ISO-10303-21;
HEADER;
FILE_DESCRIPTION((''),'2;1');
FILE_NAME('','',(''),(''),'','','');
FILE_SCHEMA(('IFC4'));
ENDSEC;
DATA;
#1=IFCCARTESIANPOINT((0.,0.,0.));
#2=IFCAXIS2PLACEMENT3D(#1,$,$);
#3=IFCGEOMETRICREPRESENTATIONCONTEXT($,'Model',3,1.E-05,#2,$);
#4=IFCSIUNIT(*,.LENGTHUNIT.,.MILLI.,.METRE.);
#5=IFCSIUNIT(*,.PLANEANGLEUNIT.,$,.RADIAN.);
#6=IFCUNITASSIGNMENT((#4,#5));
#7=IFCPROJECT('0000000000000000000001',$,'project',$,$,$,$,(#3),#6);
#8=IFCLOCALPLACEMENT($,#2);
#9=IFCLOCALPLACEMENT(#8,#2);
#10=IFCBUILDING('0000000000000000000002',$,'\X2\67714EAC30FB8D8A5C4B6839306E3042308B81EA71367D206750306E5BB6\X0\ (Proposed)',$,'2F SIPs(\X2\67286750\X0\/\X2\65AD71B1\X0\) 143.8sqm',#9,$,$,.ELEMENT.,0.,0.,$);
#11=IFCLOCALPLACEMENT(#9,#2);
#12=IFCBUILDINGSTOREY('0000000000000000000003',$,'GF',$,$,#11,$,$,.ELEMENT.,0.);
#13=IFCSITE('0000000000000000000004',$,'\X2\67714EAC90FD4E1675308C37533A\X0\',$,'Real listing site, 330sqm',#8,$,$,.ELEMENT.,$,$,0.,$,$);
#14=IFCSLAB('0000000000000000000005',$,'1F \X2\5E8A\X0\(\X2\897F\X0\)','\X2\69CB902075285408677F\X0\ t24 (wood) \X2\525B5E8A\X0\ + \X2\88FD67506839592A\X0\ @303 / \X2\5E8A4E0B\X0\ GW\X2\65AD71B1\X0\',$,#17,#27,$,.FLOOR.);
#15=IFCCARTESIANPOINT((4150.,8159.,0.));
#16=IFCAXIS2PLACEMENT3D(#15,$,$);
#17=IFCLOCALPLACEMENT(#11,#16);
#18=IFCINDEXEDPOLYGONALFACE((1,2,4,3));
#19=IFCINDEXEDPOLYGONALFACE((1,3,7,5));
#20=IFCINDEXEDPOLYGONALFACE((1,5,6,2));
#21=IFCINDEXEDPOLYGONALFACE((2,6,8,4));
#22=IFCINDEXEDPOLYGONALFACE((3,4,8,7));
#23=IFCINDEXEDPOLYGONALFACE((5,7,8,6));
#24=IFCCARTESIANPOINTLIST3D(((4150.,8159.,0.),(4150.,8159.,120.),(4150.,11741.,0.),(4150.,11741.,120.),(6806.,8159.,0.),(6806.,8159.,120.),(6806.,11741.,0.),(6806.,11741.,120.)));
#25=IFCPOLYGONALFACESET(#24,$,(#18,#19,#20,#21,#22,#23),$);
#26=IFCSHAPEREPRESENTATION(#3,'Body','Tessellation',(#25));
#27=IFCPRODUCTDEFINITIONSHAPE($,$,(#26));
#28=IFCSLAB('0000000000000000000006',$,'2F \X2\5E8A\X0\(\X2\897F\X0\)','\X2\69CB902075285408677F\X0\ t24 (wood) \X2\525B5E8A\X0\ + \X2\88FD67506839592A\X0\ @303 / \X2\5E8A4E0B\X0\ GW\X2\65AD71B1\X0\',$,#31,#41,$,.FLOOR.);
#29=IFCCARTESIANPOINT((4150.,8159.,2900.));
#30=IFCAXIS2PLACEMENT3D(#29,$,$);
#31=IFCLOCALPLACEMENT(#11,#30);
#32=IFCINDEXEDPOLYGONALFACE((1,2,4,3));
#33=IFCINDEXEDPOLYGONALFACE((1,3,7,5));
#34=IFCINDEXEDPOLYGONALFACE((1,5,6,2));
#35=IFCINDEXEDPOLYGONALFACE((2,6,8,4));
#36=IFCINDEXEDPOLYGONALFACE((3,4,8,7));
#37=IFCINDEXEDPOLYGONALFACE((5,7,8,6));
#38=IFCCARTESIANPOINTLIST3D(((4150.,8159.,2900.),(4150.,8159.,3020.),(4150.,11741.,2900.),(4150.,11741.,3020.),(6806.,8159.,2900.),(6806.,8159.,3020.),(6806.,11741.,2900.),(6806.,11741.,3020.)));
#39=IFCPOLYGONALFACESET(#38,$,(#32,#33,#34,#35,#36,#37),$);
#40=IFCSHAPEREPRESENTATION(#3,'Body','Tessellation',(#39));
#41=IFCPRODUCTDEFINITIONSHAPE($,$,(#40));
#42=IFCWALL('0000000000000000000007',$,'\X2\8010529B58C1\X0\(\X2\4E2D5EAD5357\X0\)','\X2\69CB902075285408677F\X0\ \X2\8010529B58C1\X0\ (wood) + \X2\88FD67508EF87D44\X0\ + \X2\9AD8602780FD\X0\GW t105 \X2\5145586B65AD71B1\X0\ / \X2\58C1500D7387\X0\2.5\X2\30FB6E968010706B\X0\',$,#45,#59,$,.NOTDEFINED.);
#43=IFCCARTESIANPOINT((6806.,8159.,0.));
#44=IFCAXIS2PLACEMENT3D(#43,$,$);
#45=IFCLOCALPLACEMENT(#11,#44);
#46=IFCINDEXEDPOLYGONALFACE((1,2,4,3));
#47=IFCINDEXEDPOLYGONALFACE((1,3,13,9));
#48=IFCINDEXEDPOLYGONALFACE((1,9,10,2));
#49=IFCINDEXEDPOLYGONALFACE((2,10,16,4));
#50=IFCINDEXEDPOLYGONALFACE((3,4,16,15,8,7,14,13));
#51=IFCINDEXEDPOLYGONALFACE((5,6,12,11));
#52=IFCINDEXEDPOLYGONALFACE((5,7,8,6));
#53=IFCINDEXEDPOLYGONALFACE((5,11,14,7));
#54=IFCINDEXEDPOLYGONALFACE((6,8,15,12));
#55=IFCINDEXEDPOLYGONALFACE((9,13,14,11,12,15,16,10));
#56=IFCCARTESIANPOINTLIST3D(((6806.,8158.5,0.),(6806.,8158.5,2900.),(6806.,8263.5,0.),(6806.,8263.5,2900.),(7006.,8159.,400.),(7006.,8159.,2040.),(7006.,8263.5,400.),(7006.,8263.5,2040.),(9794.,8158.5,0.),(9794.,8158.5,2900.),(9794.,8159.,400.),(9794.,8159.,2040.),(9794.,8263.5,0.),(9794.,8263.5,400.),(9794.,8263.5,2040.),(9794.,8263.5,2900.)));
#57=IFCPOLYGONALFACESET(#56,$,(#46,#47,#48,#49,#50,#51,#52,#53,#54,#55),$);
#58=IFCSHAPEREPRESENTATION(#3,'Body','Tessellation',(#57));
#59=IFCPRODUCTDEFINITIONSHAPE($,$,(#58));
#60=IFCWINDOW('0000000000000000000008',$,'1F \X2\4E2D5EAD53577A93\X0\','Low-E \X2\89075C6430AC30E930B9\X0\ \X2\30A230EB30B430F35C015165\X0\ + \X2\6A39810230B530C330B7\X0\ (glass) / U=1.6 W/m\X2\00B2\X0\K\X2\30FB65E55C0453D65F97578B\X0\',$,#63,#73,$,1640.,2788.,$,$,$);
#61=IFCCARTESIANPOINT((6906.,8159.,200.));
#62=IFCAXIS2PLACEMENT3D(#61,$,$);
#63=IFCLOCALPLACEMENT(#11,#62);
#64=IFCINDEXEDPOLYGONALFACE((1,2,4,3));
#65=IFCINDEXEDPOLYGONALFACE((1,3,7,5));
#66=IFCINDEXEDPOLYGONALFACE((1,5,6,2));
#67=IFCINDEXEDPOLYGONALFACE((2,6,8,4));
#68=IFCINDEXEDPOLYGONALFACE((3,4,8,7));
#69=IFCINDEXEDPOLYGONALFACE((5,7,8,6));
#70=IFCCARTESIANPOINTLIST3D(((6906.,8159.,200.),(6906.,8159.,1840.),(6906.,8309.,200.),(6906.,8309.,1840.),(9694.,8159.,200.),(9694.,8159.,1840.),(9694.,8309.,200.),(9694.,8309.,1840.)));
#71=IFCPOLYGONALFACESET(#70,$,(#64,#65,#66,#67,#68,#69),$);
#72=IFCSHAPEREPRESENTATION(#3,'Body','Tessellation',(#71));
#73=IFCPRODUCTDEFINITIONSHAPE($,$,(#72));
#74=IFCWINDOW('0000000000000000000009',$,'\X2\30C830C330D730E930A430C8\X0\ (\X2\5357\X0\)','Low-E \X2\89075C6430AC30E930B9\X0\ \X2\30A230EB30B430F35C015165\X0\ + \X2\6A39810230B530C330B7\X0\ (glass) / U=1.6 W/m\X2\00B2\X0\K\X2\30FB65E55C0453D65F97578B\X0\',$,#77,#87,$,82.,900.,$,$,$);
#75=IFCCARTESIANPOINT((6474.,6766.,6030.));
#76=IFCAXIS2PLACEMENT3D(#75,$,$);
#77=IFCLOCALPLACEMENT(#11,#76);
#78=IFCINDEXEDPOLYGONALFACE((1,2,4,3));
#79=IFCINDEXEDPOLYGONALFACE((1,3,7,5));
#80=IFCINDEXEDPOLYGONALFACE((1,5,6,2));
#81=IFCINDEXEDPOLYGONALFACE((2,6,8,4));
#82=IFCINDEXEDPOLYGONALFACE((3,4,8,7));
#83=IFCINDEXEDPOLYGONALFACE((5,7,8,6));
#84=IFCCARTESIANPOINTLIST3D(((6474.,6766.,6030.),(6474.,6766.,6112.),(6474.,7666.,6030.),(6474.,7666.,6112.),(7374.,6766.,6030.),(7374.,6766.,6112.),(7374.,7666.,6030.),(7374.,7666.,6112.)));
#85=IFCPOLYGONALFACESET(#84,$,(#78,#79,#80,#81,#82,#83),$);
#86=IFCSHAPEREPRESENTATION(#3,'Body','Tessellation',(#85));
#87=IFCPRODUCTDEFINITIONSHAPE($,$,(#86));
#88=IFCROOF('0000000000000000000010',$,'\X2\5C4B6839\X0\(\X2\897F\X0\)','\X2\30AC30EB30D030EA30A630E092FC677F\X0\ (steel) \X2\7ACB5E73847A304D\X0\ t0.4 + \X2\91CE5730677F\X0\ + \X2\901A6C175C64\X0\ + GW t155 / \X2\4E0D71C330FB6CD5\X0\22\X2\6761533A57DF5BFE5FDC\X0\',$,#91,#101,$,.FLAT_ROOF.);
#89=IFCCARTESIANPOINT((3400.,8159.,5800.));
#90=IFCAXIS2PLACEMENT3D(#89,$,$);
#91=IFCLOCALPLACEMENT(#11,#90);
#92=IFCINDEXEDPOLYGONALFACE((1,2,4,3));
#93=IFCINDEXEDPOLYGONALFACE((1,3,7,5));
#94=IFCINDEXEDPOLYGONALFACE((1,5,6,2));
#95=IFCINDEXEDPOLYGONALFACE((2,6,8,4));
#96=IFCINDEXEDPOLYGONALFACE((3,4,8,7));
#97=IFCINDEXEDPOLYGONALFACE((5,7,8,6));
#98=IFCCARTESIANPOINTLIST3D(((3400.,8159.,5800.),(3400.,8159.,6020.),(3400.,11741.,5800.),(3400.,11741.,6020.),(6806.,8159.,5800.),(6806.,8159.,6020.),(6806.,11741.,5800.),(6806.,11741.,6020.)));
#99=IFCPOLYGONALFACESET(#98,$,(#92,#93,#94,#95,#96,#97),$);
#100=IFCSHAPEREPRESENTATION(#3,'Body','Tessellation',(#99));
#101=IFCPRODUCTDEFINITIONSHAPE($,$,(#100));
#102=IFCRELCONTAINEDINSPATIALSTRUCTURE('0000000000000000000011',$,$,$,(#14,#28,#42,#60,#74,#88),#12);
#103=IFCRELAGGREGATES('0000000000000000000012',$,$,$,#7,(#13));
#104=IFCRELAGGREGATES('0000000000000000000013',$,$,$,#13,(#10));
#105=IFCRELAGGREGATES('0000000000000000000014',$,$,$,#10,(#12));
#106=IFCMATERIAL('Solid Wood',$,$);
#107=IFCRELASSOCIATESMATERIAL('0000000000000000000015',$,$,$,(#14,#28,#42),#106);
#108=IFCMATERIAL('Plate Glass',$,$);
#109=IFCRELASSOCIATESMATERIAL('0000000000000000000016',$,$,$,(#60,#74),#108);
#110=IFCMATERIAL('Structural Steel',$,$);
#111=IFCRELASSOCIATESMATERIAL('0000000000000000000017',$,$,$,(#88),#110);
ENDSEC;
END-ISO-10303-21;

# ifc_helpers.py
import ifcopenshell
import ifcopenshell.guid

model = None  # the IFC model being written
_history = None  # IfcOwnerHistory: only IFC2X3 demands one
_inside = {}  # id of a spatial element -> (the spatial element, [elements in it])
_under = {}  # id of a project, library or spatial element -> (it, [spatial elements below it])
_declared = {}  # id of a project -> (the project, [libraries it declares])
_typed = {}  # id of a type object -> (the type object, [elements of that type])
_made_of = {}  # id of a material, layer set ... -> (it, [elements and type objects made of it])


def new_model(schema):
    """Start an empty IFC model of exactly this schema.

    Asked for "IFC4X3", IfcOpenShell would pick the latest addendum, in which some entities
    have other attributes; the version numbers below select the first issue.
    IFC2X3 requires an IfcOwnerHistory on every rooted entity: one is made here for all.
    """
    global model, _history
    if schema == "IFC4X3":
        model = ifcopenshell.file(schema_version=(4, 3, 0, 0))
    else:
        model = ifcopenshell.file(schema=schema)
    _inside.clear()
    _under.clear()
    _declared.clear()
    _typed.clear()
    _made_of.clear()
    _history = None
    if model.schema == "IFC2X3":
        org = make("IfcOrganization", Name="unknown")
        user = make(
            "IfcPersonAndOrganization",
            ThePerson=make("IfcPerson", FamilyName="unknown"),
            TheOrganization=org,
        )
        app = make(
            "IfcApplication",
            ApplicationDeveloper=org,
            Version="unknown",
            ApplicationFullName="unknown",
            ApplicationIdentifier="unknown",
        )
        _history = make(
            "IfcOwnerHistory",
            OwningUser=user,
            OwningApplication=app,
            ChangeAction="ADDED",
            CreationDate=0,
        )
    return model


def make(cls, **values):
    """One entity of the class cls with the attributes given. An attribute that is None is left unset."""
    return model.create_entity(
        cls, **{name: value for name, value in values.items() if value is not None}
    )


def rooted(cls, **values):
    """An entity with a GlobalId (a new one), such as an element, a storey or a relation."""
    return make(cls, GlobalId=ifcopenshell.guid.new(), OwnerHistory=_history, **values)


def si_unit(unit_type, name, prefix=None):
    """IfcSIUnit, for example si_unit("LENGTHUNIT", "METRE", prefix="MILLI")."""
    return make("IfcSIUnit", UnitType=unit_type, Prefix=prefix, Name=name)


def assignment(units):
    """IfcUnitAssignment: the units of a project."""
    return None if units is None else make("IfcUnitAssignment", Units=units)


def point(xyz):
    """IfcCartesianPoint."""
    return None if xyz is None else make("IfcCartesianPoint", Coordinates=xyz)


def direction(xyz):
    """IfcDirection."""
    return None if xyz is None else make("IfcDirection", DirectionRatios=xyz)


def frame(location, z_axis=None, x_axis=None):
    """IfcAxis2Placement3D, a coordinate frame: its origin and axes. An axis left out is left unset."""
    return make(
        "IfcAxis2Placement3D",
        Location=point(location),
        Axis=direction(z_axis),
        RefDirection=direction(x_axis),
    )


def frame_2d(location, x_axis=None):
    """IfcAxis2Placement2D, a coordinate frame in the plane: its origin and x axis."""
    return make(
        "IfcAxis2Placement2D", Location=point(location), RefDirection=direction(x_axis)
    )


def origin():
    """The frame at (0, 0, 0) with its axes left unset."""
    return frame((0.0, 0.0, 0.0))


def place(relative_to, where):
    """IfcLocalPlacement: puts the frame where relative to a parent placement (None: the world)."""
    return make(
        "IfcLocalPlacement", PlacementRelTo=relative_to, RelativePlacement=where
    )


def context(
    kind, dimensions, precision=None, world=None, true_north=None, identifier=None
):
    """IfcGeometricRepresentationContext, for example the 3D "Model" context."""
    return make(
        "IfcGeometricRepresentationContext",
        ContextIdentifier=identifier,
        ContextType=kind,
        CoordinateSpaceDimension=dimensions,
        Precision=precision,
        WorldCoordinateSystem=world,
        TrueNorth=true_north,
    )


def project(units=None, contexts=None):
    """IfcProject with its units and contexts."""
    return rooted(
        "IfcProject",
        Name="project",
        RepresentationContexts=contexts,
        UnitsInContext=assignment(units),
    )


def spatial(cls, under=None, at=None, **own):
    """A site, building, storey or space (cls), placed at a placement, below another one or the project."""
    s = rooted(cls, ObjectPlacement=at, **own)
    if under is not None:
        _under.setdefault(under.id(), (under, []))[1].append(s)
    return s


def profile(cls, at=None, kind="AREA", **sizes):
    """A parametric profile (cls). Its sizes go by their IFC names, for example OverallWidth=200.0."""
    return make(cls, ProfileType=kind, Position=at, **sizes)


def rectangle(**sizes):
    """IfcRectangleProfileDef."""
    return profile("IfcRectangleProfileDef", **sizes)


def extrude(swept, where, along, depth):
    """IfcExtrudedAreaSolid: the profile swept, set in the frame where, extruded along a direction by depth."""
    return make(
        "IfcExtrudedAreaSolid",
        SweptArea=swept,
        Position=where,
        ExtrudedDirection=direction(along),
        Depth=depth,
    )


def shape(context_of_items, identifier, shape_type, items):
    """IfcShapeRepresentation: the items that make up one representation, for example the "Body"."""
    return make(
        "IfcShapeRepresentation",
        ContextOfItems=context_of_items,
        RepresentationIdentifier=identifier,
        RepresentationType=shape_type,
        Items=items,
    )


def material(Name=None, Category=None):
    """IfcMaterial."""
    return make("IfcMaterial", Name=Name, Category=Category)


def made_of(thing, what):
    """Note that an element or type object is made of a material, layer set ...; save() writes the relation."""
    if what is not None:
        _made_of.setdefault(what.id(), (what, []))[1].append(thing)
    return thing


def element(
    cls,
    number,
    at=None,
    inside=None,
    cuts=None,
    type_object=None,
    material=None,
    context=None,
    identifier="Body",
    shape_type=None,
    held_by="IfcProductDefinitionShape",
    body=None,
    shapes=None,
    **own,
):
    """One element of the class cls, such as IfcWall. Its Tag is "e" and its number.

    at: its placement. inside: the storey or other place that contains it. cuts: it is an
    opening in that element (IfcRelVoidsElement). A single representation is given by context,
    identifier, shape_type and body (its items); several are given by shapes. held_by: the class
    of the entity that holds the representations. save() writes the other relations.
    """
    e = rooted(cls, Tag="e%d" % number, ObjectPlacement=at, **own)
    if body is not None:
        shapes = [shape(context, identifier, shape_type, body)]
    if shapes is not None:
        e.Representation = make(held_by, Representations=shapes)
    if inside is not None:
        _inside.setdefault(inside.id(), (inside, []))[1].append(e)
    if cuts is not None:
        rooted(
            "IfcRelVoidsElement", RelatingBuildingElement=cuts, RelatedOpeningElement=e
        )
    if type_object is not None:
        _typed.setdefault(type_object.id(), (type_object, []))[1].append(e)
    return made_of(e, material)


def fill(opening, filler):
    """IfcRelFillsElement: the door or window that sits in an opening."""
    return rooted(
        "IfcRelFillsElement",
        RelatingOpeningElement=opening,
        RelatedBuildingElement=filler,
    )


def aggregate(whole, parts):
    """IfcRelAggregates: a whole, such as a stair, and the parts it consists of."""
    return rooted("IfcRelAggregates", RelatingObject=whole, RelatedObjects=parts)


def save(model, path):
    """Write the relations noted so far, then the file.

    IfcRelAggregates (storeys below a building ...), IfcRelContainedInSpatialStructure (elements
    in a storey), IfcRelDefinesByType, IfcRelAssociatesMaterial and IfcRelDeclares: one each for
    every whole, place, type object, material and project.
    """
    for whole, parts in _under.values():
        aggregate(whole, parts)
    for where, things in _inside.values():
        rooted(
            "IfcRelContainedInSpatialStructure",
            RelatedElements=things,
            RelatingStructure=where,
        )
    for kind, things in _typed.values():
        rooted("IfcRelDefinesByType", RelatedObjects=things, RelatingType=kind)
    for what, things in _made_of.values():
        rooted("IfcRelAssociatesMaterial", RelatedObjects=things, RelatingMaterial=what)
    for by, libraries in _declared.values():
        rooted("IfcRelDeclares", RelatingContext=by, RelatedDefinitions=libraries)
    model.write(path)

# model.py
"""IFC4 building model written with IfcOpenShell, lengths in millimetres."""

from ifc_helpers import new_model, si_unit, frame, frame_2d, origin, place, context, project, spatial, rectangle, extrude, material, element, fill, save


model = new_model("IFC4")

# Units and contexts
model_context = context("Model", 3, precision=1e-05, world=origin())
ifc_project = project(units=[si_unit("LENGTHUNIT", "METRE", prefix="MILLI"), si_unit("PLANEANGLEUNIT", "RADIAN")], contexts=[model_context])

# Site, building, storey
site_placement = place(None, origin())
site = spatial("IfcSite", under=ifc_project, at=site_placement, Name="東京都世田谷区", ObjectType="Real listing site, 330sqm", CompositionType="ELEMENT", RefElevation=0.0)
building_placement = place(site_placement, origin())
building = spatial("IfcBuilding", under=site, at=building_placement, Name="東京・越屋根のある自然素材の家 (Proposed)", ObjectType="2F SIPs(木材/断熱) 143.8sqm", CompositionType="ELEMENT", ElevationOfRefHeight=0.0, ElevationOfTerrain=0.0)
storey_placement = place(building_placement, origin())
storey = spatial("IfcBuildingStorey", under=building, at=storey_placement, Name="GF", CompositionType="ELEMENT", Elevation=0.0)

# Shared definitions
ifc_material_1 = material(Name="Solid Wood")

# Slabs
slab_1_placement = place(storey_placement, frame((4150.0, 8159.0, 0.0)))
element("IfcSlab", 1, at=slab_1_placement, inside=storey, material=ifc_material_1, Name="1F 床(西)", Description="構造用合板 t24 (wood) 剛床 + 製材根太 @303 / 床下 GW断熱", PredefinedType="FLOOR", context=model_context, shape_type="SweptSolid", body=[
    extrude(rectangle(XDim=2656.0, YDim=3582.0, at=frame_2d((1328.0, 1791.0))), frame((4150.0, 8159.0, 0.0)), (0.0, 0.0, 1.0), 120.0),
])
slab_2_placement = place(storey_placement, frame((4150.0, 8159.0, 2900.0)))
element("IfcSlab", 2, at=slab_2_placement, inside=storey, material=ifc_material_1, Name="2F 床(西)", Description="構造用合板 t24 (wood) 剛床 + 製材根太 @303 / 床下 GW断熱", PredefinedType="FLOOR", context=model_context, shape_type="SweptSolid", body=[
    extrude(rectangle(XDim=2656.0, YDim=3582.0, at=frame_2d((1328.0, 1791.0))), frame((4150.0, 8159.0, 2900.0)), (0.0, 0.0, 1.0), 120.0),
])

# Wall, opening, window
wall_1_placement = place(storey_placement, frame((6806.0, 8159.0, 0.0)))
wall_1 = element("IfcWall", 3, at=wall_1_placement, inside=storey, material=ifc_material_1, Name="耐力壁(中庭南)", Description="構造用合板 耐力壁 (wood) + 製材軸組 + 高性能GW t105 充填断熱 / 壁倍率2.5・準耐火", PredefinedType="NOTDEFINED", context=model_context, shape_type="SweptSolid", body=[
    extrude(rectangle(XDim=2988.0, YDim=105.0, at=frame_2d((1494.0, 52.0))), frame((6806.0, 8159.0, 0.0)), (0.0, 0.0, 1.0), 2900.0),
])
opening_placement = place(storey_placement, frame((6906.0, 8159.0, 200.0)))
opening = element("IfcOpeningElement", 4, at=opening_placement, cuts=wall_1, PredefinedType="NOTDEFINED", context=model_context, shape_type="SweptSolid", body=[
    extrude(rectangle(XDim=2788.0, YDim=150.0, at=frame_2d((1394.0, 75.0))), frame((6906.0, 8159.0, 200.0)), (0.0, 0.0, 1.0), 1640.0),
])
ifc_material_2 = material(Name="Plate Glass")
window_1_placement = place(storey_placement, frame((6906.0, 8159.0, 200.0)))
window_1 = element("IfcWindow", 5, at=window_1_placement, inside=storey, material=ifc_material_2, Name="1F 中庭南窓", Description="Low-E 複層ガラス アルゴン封入 + 樹脂サッシ (glass) / U=1.6 W/m²K・日射取得型", OverallHeight=1640.0, OverallWidth=2788.0, context=model_context, shape_type="SweptSolid", body=[
    extrude(rectangle(XDim=2788.0, YDim=150.0, at=frame_2d((1394.0, 75.0))), frame((6906.0, 8159.0, 200.0)), (0.0, 0.0, 1.0), 1640.0),
])
fill(opening, window_1)

# Window
window_2_placement = place(storey_placement, frame((6474.0, 6766.0, 6030.0)))
element("IfcWindow", 6, at=window_2_placement, inside=storey, material=ifc_material_2, Name="トップライト (南)", Description="Low-E 複層ガラス アルゴン封入 + 樹脂サッシ (glass) / U=1.6 W/m²K・日射取得型", OverallHeight=82.0, OverallWidth=900.0, context=model_context, shape_type="SweptSolid", body=[
    extrude(rectangle(XDim=900.0, YDim=900.0, at=frame_2d((450.0, 450.0))), frame((6474.0, 6766.0, 6030.0)), (0.0, 0.0, 1.0), 82.0),
])

# Roof
ifc_material_3 = material(Name="Structural Steel")
for number, where, name in (
    (7, (3400.0, 8159.0, 5800.0), "屋根(西)"),
):
    element("IfcRoof", number, at=place(storey_placement, frame(where)), inside=storey, material=ifc_material_3, Name=name, Description="ガルバリウム鋼板 (steel) 立平葺き t0.4 + 野地板 + 通気層 + GW t155 / 不燃・法22条区域対応", PredefinedType="FLAT_ROOF", context=model_context, shape_type="SweptSolid", body=[
        extrude(rectangle(XDim=3406.0, YDim=3582.0, at=frame_2d((1703.0, 1791.0))), frame((3400.0, 8159.0, 5800.0)), (0.0, 0.0, 1.0), 220.0),
    ])

save(model, "model.ifc")
